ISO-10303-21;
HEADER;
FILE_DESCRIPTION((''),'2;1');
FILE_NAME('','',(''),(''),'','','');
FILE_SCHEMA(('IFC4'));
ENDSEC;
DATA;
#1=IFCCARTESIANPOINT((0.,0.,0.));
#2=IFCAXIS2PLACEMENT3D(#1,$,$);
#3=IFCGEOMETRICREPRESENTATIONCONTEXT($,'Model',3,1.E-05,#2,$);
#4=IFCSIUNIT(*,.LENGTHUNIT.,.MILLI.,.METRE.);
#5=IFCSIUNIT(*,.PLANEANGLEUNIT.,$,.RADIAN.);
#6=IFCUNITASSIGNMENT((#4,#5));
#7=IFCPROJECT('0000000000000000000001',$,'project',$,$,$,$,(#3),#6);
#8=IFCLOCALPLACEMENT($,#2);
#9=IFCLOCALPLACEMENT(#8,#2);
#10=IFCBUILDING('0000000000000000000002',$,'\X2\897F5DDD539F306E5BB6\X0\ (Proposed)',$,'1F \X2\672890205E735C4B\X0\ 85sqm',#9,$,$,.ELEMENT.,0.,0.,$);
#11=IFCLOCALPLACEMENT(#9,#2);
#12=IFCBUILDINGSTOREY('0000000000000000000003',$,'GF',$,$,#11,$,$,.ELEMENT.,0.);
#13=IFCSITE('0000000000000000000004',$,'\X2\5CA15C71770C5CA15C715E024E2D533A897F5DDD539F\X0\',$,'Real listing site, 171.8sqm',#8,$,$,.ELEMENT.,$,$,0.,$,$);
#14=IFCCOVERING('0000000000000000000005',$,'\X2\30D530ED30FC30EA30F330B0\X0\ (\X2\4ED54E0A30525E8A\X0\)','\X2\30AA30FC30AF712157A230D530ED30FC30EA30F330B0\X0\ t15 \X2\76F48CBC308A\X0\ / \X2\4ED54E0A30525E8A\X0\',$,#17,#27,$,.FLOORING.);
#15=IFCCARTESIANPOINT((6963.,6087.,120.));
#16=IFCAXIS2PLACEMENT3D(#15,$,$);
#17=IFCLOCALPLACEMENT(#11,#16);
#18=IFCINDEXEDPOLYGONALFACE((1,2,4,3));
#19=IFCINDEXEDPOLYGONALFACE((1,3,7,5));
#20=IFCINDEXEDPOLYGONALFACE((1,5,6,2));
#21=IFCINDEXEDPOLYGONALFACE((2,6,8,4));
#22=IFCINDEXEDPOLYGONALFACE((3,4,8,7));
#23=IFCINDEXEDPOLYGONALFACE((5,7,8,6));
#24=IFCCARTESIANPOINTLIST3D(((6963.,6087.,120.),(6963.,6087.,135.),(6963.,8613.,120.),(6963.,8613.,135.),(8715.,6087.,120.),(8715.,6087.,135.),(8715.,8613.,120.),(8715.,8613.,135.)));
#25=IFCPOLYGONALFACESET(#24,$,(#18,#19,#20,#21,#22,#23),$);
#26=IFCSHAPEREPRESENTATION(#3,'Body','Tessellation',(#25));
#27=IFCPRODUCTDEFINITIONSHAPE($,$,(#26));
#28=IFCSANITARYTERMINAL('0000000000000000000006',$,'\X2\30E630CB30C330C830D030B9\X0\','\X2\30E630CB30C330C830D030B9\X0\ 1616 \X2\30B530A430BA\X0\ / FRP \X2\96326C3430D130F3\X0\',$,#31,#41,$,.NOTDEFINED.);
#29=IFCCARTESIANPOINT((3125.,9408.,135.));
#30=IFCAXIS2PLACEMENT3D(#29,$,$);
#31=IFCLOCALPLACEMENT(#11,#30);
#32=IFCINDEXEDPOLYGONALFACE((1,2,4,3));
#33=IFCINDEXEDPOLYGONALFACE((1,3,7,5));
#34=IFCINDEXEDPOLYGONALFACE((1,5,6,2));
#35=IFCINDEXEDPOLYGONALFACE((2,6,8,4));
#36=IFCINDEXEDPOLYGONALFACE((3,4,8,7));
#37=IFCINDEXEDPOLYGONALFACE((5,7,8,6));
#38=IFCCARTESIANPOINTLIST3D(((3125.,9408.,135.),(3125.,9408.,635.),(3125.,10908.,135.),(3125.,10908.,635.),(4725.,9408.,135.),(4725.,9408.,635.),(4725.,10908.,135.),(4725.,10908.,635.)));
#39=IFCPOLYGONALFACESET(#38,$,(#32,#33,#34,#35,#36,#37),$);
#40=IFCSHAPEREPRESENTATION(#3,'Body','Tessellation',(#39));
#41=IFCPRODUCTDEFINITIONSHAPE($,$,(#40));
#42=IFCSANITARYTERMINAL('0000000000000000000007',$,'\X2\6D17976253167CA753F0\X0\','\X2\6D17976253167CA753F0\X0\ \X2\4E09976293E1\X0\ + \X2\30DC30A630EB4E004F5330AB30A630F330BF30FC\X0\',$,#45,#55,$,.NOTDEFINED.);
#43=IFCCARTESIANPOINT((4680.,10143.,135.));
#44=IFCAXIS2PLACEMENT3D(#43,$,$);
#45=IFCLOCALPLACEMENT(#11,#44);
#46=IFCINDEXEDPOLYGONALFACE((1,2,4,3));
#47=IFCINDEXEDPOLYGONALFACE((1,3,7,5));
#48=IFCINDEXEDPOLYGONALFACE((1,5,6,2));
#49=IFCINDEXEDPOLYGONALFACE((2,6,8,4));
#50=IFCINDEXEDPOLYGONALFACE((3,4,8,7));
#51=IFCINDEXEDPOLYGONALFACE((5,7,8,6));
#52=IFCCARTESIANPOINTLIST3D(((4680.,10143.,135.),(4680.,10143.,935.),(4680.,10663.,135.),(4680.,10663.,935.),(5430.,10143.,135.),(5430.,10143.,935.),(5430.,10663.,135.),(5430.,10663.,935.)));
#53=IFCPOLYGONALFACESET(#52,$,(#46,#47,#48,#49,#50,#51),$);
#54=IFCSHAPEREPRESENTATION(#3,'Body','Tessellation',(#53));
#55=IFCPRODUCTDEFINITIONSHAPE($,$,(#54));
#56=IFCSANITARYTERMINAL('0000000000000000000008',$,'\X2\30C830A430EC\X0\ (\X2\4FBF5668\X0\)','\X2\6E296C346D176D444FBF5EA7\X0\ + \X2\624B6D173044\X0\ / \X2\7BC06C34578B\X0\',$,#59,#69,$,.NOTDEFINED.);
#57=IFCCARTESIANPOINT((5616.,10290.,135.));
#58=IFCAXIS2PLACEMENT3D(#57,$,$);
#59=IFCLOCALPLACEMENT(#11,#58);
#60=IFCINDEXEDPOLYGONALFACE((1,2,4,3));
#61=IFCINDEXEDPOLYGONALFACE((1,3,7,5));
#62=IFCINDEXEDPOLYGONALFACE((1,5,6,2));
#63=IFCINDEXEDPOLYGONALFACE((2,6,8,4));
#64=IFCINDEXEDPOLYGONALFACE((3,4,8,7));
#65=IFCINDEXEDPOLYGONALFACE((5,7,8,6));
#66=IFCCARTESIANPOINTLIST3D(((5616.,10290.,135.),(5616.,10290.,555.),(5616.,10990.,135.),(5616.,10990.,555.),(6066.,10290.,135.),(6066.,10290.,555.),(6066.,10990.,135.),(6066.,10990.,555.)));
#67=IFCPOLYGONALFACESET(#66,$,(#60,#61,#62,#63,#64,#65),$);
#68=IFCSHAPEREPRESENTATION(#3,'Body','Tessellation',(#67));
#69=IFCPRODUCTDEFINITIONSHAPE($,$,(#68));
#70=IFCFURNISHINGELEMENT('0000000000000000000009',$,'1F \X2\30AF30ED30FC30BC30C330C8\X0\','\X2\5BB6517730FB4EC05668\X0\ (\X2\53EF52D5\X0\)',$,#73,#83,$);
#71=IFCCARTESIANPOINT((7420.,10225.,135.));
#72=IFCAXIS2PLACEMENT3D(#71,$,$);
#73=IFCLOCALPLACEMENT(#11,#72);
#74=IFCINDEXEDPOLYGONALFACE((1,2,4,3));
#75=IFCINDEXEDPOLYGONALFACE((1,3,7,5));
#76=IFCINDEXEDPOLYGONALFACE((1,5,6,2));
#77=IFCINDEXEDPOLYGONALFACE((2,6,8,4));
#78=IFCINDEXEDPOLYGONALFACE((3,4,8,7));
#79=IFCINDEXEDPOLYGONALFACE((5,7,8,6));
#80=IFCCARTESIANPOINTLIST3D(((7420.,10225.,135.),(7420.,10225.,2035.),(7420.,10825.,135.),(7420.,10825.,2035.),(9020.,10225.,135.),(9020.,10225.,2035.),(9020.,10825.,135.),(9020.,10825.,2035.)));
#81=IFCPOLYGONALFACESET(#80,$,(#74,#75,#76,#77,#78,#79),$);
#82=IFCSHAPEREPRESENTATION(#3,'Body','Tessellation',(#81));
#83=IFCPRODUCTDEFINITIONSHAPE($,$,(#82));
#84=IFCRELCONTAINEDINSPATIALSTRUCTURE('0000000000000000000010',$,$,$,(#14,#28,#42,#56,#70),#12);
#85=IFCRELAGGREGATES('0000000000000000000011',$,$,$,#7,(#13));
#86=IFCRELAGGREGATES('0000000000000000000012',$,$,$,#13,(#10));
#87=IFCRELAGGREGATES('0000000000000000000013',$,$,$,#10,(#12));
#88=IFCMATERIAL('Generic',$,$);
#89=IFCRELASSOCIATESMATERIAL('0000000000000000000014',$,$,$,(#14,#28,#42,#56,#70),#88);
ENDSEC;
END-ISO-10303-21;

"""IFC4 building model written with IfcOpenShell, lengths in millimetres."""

from ifc_helpers import new_model, si_unit, frame, frame_2d, origin, place, context, project, spatial, rectangle, extrude, material, element, save


model = new_model("IFC4")

# Units and contexts
model_context = context("Model", 3, precision=1e-05, world=origin())
ifc_project = project(units=[si_unit("LENGTHUNIT", "METRE", prefix="MILLI"), si_unit("PLANEANGLEUNIT", "RADIAN")], contexts=[model_context])

# Site, building, storey
site_placement = place(None, origin())
site = spatial("IfcSite", under=ifc_project, at=site_placement, Name="岡山県岡山市中区西川原", ObjectType="Real listing site, 171.8sqm", CompositionType="ELEMENT", RefElevation=0.0)
building_placement = place(site_placement, origin())
building = spatial("IfcBuilding", under=site, at=building_placement, Name="西川原の家 (Proposed)", ObjectType="1F 木造平屋 85sqm", CompositionType="ELEMENT", ElevationOfRefHeight=0.0, ElevationOfTerrain=0.0)
storey_placement = place(building_placement, origin())
storey = spatial("IfcBuildingStorey", under=building, at=storey_placement, Name="GF", CompositionType="ELEMENT", Elevation=0.0)

# Covering
ifc_material_1 = material(Name="Generic")
covering_1_placement = place(storey_placement, frame((6963.0, 6087.0, 120.0)))
element("IfcCovering", 1, at=covering_1_placement, inside=storey, material=ifc_material_1, Name="フローリング (仕上げ床)", Description="オーク無垢フローリング t15 直貼り / 仕上げ床", PredefinedType="FLOORING", context=model_context, shape_type="SweptSolid", body=[
    extrude(rectangle(XDim=1752.0, YDim=2526.0, at=frame_2d((876.0, 1263.0))), frame((6963.0, 6087.0, 120.0)), (0.0, 0.0, 1.0), 15.0),
])

# Sanitary terminals
sanitary_terminal_1_placement = place(storey_placement, frame((3125.0, 9408.0, 135.0)))
element("IfcSanitaryTerminal", 2, at=sanitary_terminal_1_placement, inside=storey, material=ifc_material_1, Name="ユニットバス", Description="ユニットバス 1616 サイズ / FRP 防水パン", PredefinedType="NOTDEFINED", context=model_context, shape_type="SweptSolid", body=[
    extrude(rectangle(XDim=1600.0, YDim=1500.0, at=frame_2d((800.0, 750.0))), frame((3125.0, 9408.0, 135.0)), (0.0, 0.0, 1.0), 500.0),
])
sanitary_terminal_2_placement = place(storey_placement, frame((4680.0, 10143.0, 135.0)))
element("IfcSanitaryTerminal", 3, at=sanitary_terminal_2_placement, inside=storey, material=ifc_material_1, Name="洗面化粧台", Description="洗面化粧台 三面鏡 + ボウル一体カウンター", PredefinedType="NOTDEFINED", context=model_context, shape_type="SweptSolid", body=[
    extrude(rectangle(XDim=750.0, YDim=520.0, at=frame_2d((375.0, 260.0))), frame((4680.0, 10143.0, 135.0)), (0.0, 0.0, 1.0), 800.0),
])
sanitary_terminal_3_placement = place(storey_placement, frame((5616.0, 10290.0, 135.0)))
element("IfcSanitaryTerminal", 4, at=sanitary_terminal_3_placement, inside=storey, material=ifc_material_1, Name="トイレ (便器)", Description="温水洗浄便座 + 手洗い / 節水型", PredefinedType="NOTDEFINED", context=model_context, shape_type="SweptSolid", body=[
    extrude(rectangle(XDim=450.0, YDim=700.0, at=frame_2d((225.0, 350.0))), frame((5616.0, 10290.0, 135.0)), (0.0, 0.0, 1.0), 420.0),
])

# Furnishing element
furnishing_placement = place(storey_placement, frame((7420.0, 10225.0, 135.0)))
element("IfcFurnishingElement", 5, at=furnishing_placement, inside=storey, material=ifc_material_1, Name="1F クローゼット", Description="家具・什器 (可動)", context=model_context, shape_type="SweptSolid", body=[
    extrude(rectangle(XDim=1600.0, YDim=600.0, at=frame_2d((800.0, 300.0))), frame((7420.0, 10225.0, 135.0)), (0.0, 0.0, 1.0), 1900.0),
])

save(model, "model.ifc")
